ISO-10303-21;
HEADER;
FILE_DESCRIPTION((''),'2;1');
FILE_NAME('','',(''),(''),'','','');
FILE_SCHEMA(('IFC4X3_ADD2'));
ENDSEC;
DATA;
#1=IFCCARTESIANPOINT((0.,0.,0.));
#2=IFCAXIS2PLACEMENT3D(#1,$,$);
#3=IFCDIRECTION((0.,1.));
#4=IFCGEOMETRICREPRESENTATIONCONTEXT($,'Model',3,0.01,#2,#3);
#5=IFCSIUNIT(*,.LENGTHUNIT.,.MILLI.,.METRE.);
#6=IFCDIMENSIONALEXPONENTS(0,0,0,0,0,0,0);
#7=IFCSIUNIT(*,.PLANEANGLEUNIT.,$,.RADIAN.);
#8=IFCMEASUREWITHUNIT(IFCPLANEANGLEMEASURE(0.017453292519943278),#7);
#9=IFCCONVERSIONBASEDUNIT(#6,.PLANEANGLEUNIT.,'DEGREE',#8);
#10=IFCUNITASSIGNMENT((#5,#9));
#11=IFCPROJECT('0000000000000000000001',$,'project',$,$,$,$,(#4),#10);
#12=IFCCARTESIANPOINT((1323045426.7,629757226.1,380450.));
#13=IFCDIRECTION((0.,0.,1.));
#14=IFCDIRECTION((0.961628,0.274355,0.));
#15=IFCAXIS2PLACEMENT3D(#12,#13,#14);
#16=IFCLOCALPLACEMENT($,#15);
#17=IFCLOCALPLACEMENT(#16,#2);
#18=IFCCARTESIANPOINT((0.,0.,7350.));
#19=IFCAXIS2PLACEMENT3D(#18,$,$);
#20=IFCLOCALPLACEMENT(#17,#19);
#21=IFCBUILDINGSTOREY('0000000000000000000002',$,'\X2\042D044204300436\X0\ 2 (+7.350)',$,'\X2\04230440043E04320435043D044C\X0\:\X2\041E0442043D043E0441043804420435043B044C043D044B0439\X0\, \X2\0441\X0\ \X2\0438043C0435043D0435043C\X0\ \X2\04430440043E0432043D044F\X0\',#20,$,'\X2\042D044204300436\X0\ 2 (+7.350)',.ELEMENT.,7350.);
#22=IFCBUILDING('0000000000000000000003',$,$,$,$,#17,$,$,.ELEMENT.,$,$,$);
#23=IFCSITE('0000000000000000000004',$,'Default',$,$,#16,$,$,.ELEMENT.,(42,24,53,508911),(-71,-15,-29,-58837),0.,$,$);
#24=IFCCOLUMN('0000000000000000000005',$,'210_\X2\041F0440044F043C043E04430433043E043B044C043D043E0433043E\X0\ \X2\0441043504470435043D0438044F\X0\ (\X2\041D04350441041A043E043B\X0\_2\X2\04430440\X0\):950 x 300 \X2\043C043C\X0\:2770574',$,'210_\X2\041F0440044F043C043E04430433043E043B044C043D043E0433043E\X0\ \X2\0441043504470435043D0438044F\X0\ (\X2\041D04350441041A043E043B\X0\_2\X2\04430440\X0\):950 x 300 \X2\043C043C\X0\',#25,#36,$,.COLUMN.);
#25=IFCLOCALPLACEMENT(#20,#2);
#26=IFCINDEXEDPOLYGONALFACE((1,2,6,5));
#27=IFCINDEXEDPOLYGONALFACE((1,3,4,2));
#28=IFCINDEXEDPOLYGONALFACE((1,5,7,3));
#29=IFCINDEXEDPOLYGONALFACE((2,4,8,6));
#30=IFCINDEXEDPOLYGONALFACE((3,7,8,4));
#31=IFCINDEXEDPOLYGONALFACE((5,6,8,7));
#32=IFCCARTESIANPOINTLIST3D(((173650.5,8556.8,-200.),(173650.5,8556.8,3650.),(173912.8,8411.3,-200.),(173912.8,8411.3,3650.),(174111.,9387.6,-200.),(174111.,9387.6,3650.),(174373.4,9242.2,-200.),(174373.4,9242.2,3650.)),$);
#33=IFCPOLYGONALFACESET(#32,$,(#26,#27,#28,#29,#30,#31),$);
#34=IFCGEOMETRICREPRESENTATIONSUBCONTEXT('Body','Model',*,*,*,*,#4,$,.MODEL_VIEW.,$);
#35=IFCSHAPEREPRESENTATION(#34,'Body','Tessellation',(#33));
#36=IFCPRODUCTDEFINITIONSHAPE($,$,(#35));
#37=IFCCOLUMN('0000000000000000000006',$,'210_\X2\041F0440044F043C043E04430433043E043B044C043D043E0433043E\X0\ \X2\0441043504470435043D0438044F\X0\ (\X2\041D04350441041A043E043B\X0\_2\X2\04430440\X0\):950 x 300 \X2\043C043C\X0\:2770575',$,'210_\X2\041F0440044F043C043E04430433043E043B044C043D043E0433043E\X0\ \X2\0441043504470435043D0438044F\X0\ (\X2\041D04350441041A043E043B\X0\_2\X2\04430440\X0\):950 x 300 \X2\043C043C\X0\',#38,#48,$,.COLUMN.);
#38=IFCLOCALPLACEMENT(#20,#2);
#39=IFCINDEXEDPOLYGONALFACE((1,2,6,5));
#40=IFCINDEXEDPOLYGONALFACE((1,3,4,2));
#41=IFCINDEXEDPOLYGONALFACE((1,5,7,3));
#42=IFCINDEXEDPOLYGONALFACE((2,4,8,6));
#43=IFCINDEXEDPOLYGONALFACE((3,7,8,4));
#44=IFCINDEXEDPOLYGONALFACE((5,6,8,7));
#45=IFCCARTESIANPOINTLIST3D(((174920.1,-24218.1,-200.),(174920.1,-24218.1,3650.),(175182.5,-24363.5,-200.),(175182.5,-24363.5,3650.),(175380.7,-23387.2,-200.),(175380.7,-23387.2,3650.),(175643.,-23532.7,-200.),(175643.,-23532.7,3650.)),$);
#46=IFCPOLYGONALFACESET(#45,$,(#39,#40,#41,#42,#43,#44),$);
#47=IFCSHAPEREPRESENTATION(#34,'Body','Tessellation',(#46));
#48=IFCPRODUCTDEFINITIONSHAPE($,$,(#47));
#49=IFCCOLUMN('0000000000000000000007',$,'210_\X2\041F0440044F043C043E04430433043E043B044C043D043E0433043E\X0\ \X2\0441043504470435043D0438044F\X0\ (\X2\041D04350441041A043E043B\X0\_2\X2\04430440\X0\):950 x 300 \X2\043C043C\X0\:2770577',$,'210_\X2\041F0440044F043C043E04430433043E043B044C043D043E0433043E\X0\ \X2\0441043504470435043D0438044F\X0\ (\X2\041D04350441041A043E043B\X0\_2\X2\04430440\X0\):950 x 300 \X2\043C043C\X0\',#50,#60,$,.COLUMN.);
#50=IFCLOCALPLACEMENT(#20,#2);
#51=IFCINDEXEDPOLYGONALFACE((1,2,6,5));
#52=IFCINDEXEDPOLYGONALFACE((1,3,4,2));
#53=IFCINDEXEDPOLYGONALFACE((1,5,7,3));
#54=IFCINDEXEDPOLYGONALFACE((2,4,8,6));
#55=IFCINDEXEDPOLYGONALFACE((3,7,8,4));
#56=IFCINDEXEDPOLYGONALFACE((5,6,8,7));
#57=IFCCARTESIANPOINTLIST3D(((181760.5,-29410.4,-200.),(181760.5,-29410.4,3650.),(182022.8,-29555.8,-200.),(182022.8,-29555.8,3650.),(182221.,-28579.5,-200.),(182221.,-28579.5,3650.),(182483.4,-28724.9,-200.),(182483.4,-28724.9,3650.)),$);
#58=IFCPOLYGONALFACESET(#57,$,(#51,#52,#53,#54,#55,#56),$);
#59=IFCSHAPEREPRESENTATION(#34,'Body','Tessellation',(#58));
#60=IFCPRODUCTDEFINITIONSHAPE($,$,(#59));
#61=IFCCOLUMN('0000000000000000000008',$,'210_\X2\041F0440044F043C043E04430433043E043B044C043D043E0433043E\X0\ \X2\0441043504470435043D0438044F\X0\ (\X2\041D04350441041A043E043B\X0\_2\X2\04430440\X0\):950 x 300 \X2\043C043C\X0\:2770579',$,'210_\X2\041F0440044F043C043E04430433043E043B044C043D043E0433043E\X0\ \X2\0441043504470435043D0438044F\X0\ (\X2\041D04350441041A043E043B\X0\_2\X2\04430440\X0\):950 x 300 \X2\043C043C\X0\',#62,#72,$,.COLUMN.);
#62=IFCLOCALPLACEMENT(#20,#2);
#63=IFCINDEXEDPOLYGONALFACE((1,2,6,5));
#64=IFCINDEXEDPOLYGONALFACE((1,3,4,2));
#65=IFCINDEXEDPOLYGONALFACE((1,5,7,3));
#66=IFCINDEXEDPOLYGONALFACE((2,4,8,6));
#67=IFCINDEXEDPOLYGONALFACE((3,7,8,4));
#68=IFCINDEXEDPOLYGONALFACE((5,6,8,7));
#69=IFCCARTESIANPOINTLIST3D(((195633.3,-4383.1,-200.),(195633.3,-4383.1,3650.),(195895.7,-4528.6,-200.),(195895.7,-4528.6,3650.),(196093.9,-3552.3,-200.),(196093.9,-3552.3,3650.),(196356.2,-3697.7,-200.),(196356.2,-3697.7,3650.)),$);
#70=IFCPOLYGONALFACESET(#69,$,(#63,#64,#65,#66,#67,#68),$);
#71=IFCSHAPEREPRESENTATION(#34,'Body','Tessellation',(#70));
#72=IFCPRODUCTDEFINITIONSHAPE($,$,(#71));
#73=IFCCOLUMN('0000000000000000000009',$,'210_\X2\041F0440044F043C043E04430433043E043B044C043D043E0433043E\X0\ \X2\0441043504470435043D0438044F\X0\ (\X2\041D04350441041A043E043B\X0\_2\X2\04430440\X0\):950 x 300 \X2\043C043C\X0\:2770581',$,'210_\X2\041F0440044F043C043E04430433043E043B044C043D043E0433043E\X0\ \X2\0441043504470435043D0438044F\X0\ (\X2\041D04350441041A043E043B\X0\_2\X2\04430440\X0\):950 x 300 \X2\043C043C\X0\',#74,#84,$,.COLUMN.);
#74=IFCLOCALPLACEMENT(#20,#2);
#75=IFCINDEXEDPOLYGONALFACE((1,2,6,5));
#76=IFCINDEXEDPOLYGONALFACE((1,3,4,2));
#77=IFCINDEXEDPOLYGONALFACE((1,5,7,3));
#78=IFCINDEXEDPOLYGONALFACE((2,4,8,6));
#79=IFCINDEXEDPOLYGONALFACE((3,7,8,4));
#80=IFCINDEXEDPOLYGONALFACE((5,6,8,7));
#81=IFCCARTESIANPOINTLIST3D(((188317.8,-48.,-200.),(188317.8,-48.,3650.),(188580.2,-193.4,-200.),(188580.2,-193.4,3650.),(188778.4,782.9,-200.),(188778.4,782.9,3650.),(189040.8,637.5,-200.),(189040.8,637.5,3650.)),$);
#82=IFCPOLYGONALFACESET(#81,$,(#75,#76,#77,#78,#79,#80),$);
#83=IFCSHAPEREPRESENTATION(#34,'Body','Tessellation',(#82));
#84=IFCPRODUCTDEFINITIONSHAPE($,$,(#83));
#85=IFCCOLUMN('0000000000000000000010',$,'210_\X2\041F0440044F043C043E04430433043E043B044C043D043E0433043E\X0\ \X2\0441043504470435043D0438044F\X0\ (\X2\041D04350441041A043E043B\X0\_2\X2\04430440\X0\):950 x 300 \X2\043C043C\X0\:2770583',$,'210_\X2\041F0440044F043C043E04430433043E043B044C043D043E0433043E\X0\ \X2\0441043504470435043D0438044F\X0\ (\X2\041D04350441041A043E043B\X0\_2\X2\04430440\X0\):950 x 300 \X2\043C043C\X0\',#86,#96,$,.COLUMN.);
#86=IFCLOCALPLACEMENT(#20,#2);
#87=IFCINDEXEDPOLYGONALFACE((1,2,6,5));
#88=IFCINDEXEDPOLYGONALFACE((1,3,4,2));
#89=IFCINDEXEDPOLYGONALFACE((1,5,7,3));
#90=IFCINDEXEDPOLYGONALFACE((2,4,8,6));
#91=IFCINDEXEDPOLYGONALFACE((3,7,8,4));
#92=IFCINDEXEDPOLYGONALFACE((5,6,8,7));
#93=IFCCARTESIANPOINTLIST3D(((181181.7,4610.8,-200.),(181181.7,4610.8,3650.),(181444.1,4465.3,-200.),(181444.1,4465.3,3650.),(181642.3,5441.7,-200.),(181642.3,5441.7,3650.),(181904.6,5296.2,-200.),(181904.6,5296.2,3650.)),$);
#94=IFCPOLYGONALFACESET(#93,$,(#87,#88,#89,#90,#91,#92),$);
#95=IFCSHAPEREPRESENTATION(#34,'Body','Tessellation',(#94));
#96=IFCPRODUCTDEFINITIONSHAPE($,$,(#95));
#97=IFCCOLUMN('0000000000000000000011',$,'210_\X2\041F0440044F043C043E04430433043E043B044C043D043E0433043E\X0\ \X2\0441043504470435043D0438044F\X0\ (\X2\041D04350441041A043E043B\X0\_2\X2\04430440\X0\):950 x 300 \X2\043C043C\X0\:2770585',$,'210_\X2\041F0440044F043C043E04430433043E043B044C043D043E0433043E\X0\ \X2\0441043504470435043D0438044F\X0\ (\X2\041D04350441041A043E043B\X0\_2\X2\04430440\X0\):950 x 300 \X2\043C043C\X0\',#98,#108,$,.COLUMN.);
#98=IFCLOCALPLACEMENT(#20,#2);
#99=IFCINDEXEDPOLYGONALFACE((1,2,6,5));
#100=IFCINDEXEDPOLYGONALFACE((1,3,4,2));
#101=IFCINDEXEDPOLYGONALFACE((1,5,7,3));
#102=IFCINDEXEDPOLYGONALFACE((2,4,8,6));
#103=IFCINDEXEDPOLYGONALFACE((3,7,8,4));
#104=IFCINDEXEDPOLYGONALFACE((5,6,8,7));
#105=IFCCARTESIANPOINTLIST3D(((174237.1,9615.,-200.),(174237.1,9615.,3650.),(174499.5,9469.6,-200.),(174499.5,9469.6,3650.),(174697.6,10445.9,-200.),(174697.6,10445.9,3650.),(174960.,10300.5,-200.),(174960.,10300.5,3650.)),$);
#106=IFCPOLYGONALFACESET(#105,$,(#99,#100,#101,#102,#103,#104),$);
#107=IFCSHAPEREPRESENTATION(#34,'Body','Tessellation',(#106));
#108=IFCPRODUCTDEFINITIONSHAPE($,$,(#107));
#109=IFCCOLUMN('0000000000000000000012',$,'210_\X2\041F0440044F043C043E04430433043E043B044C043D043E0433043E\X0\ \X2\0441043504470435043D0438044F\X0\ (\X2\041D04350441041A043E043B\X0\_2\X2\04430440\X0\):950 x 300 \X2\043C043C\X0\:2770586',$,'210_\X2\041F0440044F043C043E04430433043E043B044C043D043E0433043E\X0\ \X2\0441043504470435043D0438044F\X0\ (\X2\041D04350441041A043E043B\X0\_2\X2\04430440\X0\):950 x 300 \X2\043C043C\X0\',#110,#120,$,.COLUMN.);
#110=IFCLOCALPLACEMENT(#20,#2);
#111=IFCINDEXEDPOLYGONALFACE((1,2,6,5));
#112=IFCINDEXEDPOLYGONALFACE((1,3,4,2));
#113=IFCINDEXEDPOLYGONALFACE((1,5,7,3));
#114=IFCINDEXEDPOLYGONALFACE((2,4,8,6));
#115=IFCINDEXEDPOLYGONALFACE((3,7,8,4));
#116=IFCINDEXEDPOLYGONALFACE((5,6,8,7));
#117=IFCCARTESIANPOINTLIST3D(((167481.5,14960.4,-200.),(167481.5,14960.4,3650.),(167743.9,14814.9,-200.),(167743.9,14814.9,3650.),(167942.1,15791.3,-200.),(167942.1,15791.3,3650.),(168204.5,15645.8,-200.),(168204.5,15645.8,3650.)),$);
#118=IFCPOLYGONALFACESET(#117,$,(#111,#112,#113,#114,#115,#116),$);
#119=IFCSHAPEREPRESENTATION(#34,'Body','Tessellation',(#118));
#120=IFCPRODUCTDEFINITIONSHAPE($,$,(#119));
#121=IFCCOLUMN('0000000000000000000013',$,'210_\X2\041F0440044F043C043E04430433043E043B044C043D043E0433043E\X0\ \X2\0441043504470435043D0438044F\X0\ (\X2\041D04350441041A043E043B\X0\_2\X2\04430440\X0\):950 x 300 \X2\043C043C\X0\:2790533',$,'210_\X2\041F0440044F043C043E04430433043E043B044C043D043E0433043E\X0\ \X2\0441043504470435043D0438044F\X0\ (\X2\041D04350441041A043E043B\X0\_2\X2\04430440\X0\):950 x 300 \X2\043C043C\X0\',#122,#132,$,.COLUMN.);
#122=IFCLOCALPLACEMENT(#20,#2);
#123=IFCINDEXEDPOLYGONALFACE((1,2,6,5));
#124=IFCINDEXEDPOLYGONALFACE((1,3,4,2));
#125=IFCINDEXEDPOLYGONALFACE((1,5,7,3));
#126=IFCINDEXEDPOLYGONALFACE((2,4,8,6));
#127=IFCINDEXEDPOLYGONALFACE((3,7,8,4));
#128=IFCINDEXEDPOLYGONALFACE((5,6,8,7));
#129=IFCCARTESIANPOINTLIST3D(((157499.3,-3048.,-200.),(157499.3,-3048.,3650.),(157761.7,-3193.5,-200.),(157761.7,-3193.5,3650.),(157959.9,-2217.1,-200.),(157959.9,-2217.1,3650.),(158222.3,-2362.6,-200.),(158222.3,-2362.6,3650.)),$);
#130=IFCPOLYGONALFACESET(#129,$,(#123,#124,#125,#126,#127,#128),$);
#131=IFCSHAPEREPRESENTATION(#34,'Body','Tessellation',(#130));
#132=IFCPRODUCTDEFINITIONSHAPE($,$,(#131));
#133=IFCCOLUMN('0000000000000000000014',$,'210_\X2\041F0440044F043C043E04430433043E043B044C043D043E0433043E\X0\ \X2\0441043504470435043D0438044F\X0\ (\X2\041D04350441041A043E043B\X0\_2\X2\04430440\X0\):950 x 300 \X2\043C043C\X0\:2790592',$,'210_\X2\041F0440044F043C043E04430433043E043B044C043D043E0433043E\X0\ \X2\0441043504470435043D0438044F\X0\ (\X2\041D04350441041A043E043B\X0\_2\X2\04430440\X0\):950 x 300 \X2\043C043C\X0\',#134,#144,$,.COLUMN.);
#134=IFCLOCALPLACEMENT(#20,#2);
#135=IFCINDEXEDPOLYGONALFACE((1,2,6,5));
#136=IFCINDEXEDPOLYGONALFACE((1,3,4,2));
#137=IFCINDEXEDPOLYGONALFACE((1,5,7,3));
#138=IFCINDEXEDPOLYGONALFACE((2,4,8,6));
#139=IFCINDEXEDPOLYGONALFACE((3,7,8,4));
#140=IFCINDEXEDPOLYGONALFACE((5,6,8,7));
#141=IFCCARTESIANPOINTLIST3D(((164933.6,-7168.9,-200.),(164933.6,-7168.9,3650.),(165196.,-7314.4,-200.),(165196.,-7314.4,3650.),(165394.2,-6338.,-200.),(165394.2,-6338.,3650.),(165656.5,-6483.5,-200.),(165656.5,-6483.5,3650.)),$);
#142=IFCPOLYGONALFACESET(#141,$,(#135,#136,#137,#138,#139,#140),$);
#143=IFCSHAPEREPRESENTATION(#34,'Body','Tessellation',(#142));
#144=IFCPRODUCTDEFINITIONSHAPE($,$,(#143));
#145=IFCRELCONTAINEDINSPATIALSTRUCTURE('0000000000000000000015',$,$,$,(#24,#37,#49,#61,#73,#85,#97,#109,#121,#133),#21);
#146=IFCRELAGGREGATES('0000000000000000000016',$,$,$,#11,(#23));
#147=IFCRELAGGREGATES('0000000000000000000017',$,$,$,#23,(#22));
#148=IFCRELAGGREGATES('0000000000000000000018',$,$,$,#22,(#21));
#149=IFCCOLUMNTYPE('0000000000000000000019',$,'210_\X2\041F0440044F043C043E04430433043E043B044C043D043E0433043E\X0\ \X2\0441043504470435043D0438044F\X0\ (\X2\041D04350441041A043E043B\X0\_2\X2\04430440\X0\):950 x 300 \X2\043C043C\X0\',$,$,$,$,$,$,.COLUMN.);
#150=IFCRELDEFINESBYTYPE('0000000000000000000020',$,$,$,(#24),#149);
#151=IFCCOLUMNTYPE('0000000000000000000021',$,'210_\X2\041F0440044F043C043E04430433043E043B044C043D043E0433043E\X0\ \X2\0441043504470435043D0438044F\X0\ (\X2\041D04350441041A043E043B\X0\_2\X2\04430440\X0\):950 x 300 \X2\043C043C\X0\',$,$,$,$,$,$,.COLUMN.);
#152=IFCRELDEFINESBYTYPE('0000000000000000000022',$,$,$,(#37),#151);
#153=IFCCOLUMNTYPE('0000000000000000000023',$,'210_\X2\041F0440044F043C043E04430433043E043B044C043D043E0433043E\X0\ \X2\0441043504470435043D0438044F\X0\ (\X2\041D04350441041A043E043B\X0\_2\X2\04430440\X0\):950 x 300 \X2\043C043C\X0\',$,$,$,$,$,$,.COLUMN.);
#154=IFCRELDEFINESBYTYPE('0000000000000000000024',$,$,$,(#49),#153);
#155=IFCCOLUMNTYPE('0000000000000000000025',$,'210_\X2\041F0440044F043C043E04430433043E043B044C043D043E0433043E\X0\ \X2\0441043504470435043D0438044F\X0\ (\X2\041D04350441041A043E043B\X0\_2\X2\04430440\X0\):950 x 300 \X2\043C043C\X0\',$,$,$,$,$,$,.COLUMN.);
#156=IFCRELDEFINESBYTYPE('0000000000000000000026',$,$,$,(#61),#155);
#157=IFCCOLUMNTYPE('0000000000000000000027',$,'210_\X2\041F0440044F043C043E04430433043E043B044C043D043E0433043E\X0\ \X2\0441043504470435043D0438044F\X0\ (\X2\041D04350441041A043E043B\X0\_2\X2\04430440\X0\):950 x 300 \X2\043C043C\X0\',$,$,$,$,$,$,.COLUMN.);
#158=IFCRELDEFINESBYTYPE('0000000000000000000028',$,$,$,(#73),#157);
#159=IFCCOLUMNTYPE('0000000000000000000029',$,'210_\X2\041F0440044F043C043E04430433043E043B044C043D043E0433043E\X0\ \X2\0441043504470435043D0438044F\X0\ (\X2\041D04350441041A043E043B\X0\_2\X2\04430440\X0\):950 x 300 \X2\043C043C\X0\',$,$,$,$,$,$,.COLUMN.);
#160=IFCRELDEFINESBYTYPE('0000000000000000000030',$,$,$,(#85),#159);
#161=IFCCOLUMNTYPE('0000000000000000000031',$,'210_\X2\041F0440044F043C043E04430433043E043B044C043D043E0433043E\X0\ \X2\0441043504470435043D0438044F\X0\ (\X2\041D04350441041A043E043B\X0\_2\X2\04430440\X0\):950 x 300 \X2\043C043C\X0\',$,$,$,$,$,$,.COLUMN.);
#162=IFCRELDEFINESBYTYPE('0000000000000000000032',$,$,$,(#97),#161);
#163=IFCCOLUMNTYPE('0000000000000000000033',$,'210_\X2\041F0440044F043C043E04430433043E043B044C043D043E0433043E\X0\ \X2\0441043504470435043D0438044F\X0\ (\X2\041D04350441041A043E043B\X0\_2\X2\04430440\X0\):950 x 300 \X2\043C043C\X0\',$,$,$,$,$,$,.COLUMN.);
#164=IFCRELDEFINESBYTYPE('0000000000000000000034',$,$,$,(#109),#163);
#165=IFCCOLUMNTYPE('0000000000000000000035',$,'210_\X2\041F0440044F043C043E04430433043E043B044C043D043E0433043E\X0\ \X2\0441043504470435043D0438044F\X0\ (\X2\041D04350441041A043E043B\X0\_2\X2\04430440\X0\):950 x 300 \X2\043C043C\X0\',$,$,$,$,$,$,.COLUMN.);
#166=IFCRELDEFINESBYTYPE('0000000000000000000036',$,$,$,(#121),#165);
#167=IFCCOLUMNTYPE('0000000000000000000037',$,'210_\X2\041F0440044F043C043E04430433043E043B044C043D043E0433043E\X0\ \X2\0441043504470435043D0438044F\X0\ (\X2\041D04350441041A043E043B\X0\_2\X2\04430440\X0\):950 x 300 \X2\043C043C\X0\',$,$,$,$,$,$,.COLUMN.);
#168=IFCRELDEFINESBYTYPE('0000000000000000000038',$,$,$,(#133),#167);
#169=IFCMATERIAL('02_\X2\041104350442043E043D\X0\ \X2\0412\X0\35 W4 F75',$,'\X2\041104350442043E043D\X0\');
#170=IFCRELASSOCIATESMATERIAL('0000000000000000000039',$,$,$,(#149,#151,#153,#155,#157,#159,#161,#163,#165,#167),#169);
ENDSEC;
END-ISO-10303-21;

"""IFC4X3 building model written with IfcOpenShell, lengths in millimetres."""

from ifc_helpers import new_model, entity, si_unit, converted_unit, direction, frame, frame_2d, origin, origin_2d_with_axis, place, context, subcontext, project, spatial, rectangle, extrude, source, transform, mapped, material, material_profile, profile_set, type_object, type_shapes, element, save


model = new_model("IFC4X3")

# Units and contexts
model_context = context("Model", 3, precision=0.01, world=origin(), true_north=direction((0.0, 1.0)))
body_context = subcontext(model_context, "Body", "Model", "MODEL_VIEW")
ifc_project = project(units=[si_unit("LENGTHUNIT", "METRE", prefix="MILLI"), converted_unit("PLANEANGLEUNIT", "DEGREE", entity("IfcPlaneAngleMeasure", 0.017453292519943278), si_unit("PLANEANGLEUNIT", "RADIAN"), dimensions=[0, 0, 0, 0, 0, 0, 0])], contexts=[model_context])

# Site, building, storey
site_placement = place(None, frame((1323045426.7, 629757226.1, 380450.0), z_axis=(0.0, 0.0, 1.0), x_axis=(0.961628, 0.274355, 0.0)))
site = spatial("IfcSite", under=ifc_project, at=site_placement, Name="Default", CompositionType="ELEMENT", RefLatitude=(42, 24, 53, 508911), RefLongitude=(-71, -15, -29, -58837), RefElevation=0.0)
building_placement = place(site_placement, origin())
building = spatial("IfcBuilding", under=site, at=building_placement, CompositionType="ELEMENT")
storey_placement = place(building_placement, frame((0.0, 0.0, 7350.0)))
storey = spatial("IfcBuildingStorey", under=building, at=storey_placement, Name="Этаж 2 (+7.350)", ObjectType="Уровень:Относительный, с именем уровня", LongName="Этаж 2 (+7.350)", CompositionType="ELEMENT", Elevation=7350.0)

# Columns
ifc_material = material(Name="02_Бетон В35 W4 F75", Category="Бетон")
ifc_material_profile = material_profile(ifc_material, rectangle(XDim=300.0, YDim=950.0, at=origin_2d_with_axis()), Name="950 x 300 мм")
ifc_profile_set = profile_set([ifc_material_profile], Name="950 x 300 мм")
column_type_1 = type_object("IfcColumnType", Name="210_Прямоугольного сечения (НесКол_2ур):950 x 300 мм", PredefinedType="COLUMN", material=ifc_profile_set)
shared_shape_1 = source(origin(), body_context, "Body", "SweptSolid", [
    extrude(rectangle(XDim=300.0, YDim=950.0, at=origin_2d_with_axis()), frame((174011.9, 8899.5, 7150.0), z_axis=(0.0, 0.0, 1.0), x_axis=(-0.87462, 0.48481, 0.0)), (0.0, 0.0, 1.0), 3850.0),
])
type_shapes(column_type_1, [shared_shape_1])
column_1_placement = place(storey_placement, frame((0.0, 0.0, -7350.0)))
element("IfcColumn", 1, at=column_1_placement, inside=storey, type_object=column_type_1, Name="210_Прямоугольного сечения (НесКол_2ур):950 x 300 мм:2770574", ObjectType="210_Прямоугольного сечения (НесКол_2ур):950 x 300 мм", PredefinedType="COLUMN", context=body_context, shape_type="MappedRepresentation", body=[
    mapped(shared_shape_1, transform((0.0, 0.0, 0.0), scale=1.0)),
])
column_type_2 = type_object("IfcColumnType", Name="210_Прямоугольного сечения (НесКол_2ур):950 x 300 мм", PredefinedType="COLUMN", material=ifc_profile_set)
shared_shape_2 = source(origin(), body_context, "Body", "SweptSolid", [
    extrude(rectangle(XDim=300.0, YDim=950.0, at=frame_2d((0.0, 0.0), x_axis=(1.0, 0.0))), frame((175281.6, -23875.4, 7150.0), z_axis=(0.0, 0.0, 1.0), x_axis=(-0.87462, 0.48481, 0.0)), (0.0, 0.0, 1.0), 3850.0),
])
type_shapes(column_type_2, [shared_shape_2])
column_2_placement = place(storey_placement, frame((0.0, 0.0, -7350.0)))
element("IfcColumn", 2, at=column_2_placement, inside=storey, type_object=column_type_2, Name="210_Прямоугольного сечения (НесКол_2ур):950 x 300 мм:2770575", ObjectType="210_Прямоугольного сечения (НесКол_2ур):950 x 300 мм", PredefinedType="COLUMN", context=body_context, shape_type="MappedRepresentation", body=[
    mapped(shared_shape_2, transform((0.0, 0.0, 0.0), scale=1.0)),
])
column_type_3 = type_object("IfcColumnType", Name="210_Прямоугольного сечения (НесКол_2ур):950 x 300 мм", PredefinedType="COLUMN", material=ifc_profile_set)
shared_shape_3 = source(origin(), body_context, "Body", "SweptSolid", [
    extrude(rectangle(XDim=300.0, YDim=950.0, at=frame_2d((0.0, 0.0), x_axis=(1.0, 0.0))), frame((182121.9, -29067.7, 7150.0), z_axis=(0.0, 0.0, 1.0), x_axis=(-0.87462, 0.48481, 0.0)), (0.0, 0.0, 1.0), 3850.0),
])
type_shapes(column_type_3, [shared_shape_3])
column_3_placement = place(storey_placement, frame((0.0, 0.0, -7350.0)))
element("IfcColumn", 3, at=column_3_placement, inside=storey, type_object=column_type_3, Name="210_Прямоугольного сечения (НесКол_2ур):950 x 300 мм:2770577", ObjectType="210_Прямоугольного сечения (НесКол_2ур):950 x 300 мм", PredefinedType="COLUMN", context=body_context, shape_type="MappedRepresentation", body=[
    mapped(shared_shape_3, transform((0.0, 0.0, 0.0), scale=1.0)),
])
column_type_4 = type_object("IfcColumnType", Name="210_Прямоугольного сечения (НесКол_2ур):950 x 300 мм", PredefinedType="COLUMN", material=ifc_profile_set)
shared_shape_4 = source(origin(), body_context, "Body", "SweptSolid", [
    extrude(rectangle(XDim=300.0, YDim=950.0, at=frame_2d((0.0, 0.0), x_axis=(1.0, 0.0))), frame((195994.8, -4040.4, 7150.0), z_axis=(0.0, 0.0, 1.0), x_axis=(-0.87462, 0.48481, 0.0)), (0.0, 0.0, 1.0), 3850.0),
])
type_shapes(column_type_4, [shared_shape_4])
column_4_placement = place(storey_placement, frame((0.0, 0.0, -7350.0)))
element("IfcColumn", 4, at=column_4_placement, inside=storey, type_object=column_type_4, Name="210_Прямоугольного сечения (НесКол_2ур):950 x 300 мм:2770579", ObjectType="210_Прямоугольного сечения (НесКол_2ур):950 x 300 мм", PredefinedType="COLUMN", context=body_context, shape_type="MappedRepresentation", body=[
    mapped(shared_shape_4, transform((0.0, 0.0, 0.0), scale=1.0)),
])
column_type_5 = type_object("IfcColumnType", Name="210_Прямоугольного сечения (НесКол_2ур):950 x 300 мм", PredefinedType="COLUMN", material=ifc_profile_set)
shared_shape_5 = source(origin(), body_context, "Body", "SweptSolid", [
    extrude(rectangle(XDim=300.0, YDim=950.0, at=origin_2d_with_axis()), frame((188679.3, 294.7, 7150.0), z_axis=(0.0, 0.0, 1.0), x_axis=(-0.87462, 0.48481, 0.0)), (0.0, 0.0, 1.0), 3850.0),
])
type_shapes(column_type_5, [shared_shape_5])
column_5_placement = place(storey_placement, frame((0.0, 0.0, -7350.0)))
element("IfcColumn", 5, at=column_5_placement, inside=storey, type_object=column_type_5, Name="210_Прямоугольного сечения (НесКол_2ур):950 x 300 мм:2770581", ObjectType="210_Прямоугольного сечения (НесКол_2ур):950 x 300 мм", PredefinedType="COLUMN", context=body_context, shape_type="MappedRepresentation", body=[
    mapped(shared_shape_5, transform((0.0, 0.0, 0.0), scale=1.0)),
])
column_type_6 = type_object("IfcColumnType", Name="210_Прямоугольного сечения (НесКол_2ур):950 x 300 мм", PredefinedType="COLUMN", material=ifc_profile_set)
shared_shape_6 = source(origin(), body_context, "Body", "SweptSolid", [
    extrude(rectangle(XDim=300.0, YDim=950.0, at=origin_2d_with_axis()), frame((181543.2, 4953.5, 7150.0), z_axis=(0.0, 0.0, 1.0), x_axis=(-0.87462, 0.48481, 0.0)), (0.0, 0.0, 1.0), 3850.0),
])
type_shapes(column_type_6, [shared_shape_6])
column_6_placement = place(storey_placement, frame((0.0, 0.0, -7350.0)))
element("IfcColumn", 6, at=column_6_placement, inside=storey, type_object=column_type_6, Name="210_Прямоугольного сечения (НесКол_2ур):950 x 300 мм:2770583", ObjectType="210_Прямоугольного сечения (НесКол_2ур):950 x 300 мм", PredefinedType="COLUMN", context=body_context, shape_type="MappedRepresentation", body=[
    mapped(shared_shape_6, transform((0.0, 0.0, 0.0), scale=1.0)),
])
column_type_7 = type_object("IfcColumnType", Name="210_Прямоугольного сечения (НесКол_2ур):950 x 300 мм", PredefinedType="COLUMN", material=ifc_profile_set)
shared_shape_7 = source(origin(), body_context, "Body", "SweptSolid", [
    extrude(rectangle(XDim=300.0, YDim=950.0, at=origin_2d_with_axis()), frame((174598.6, 9957.8, 7150.0), z_axis=(0.0, 0.0, 1.0), x_axis=(-0.87462, 0.48481, 0.0)), (0.0, 0.0, 1.0), 3850.0),
])
type_shapes(column_type_7, [shared_shape_7])
column_7_placement = place(storey_placement, frame((0.0, 0.0, -7350.0)))
element("IfcColumn", 7, at=column_7_placement, inside=storey, type_object=column_type_7, Name="210_Прямоугольного сечения (НесКол_2ур):950 x 300 мм:2770585", ObjectType="210_Прямоугольного сечения (НесКол_2ур):950 x 300 мм", PredefinedType="COLUMN", context=body_context, shape_type="MappedRepresentation", body=[
    mapped(shared_shape_7, transform((0.0, 0.0, 0.0), scale=1.0)),
])
column_type_8 = type_object("IfcColumnType", Name="210_Прямоугольного сечения (НесКол_2ур):950 x 300 мм", PredefinedType="COLUMN", material=ifc_profile_set)
shared_shape_8 = source(origin(), body_context, "Body", "SweptSolid", [
    extrude(rectangle(XDim=300.0, YDim=950.0, at=origin_2d_with_axis()), frame((167843.0, 15303.1, 7150.0), z_axis=(0.0, 0.0, 1.0), x_axis=(-0.87462, 0.48481, 0.0)), (0.0, 0.0, 1.0), 3850.0),
])
type_shapes(column_type_8, [shared_shape_8])
column_8_placement = place(storey_placement, frame((0.0, 0.0, -7350.0)))
element("IfcColumn", 8, at=column_8_placement, inside=storey, type_object=column_type_8, Name="210_Прямоугольного сечения (НесКол_2ур):950 x 300 мм:2770586", ObjectType="210_Прямоугольного сечения (НесКол_2ур):950 x 300 мм", PredefinedType="COLUMN", context=body_context, shape_type="MappedRepresentation", body=[
    mapped(shared_shape_8, transform((0.0, 0.0, 0.0), scale=1.0)),
])
column_type_9 = type_object("IfcColumnType", Name="210_Прямоугольного сечения (НесКол_2ур):950 x 300 мм", PredefinedType="COLUMN", material=ifc_profile_set)
shared_shape_9 = source(origin(), body_context, "Body", "SweptSolid", [
    extrude(rectangle(XDim=300.0, YDim=950.0, at=frame_2d((0.0, 0.0), x_axis=(1.0, 0.0))), frame((157860.8, -2705.3, 7150.0), z_axis=(0.0, 0.0, 1.0), x_axis=(-0.87462, 0.48481, 0.0)), (0.0, 0.0, 1.0), 3850.0),
])
type_shapes(column_type_9, [shared_shape_9])
column_9_placement = place(storey_placement, frame((0.0, 0.0, -7350.0)))
element("IfcColumn", 9, at=column_9_placement, inside=storey, type_object=column_type_9, Name="210_Прямоугольного сечения (НесКол_2ур):950 x 300 мм:2790533", ObjectType="210_Прямоугольного сечения (НесКол_2ур):950 x 300 мм", PredefinedType="COLUMN", context=body_context, shape_type="MappedRepresentation", body=[
    mapped(shared_shape_9, transform((0.0, 0.0, 0.0), scale=1.0)),
])
column_type_10 = type_object("IfcColumnType", Name="210_Прямоугольного сечения (НесКол_2ур):950 x 300 мм", PredefinedType="COLUMN", material=ifc_profile_set)
shared_shape_10 = source(origin(), body_context, "Body", "SweptSolid", [
    extrude(rectangle(XDim=300.0, YDim=950.0, at=origin_2d_with_axis()), frame((165295.1, -6826.2, 7150.0), z_axis=(0.0, 0.0, 1.0), x_axis=(-0.87462, 0.48481, 0.0)), (0.0, 0.0, 1.0), 3850.0),
])
type_shapes(column_type_10, [shared_shape_10])
column_10_placement = place(storey_placement, frame((0.0, 0.0, -7350.0)))
element("IfcColumn", 10, at=column_10_placement, inside=storey, type_object=column_type_10, Name="210_Прямоугольного сечения (НесКол_2ур):950 x 300 мм:2790592", ObjectType="210_Прямоугольного сечения (НесКол_2ур):950 x 300 мм", PredefinedType="COLUMN", context=body_context, shape_type="MappedRepresentation", body=[
    mapped(shared_shape_10, transform((0.0, 0.0, 0.0), scale=1.0)),
])

save(model, "model.ifc")
